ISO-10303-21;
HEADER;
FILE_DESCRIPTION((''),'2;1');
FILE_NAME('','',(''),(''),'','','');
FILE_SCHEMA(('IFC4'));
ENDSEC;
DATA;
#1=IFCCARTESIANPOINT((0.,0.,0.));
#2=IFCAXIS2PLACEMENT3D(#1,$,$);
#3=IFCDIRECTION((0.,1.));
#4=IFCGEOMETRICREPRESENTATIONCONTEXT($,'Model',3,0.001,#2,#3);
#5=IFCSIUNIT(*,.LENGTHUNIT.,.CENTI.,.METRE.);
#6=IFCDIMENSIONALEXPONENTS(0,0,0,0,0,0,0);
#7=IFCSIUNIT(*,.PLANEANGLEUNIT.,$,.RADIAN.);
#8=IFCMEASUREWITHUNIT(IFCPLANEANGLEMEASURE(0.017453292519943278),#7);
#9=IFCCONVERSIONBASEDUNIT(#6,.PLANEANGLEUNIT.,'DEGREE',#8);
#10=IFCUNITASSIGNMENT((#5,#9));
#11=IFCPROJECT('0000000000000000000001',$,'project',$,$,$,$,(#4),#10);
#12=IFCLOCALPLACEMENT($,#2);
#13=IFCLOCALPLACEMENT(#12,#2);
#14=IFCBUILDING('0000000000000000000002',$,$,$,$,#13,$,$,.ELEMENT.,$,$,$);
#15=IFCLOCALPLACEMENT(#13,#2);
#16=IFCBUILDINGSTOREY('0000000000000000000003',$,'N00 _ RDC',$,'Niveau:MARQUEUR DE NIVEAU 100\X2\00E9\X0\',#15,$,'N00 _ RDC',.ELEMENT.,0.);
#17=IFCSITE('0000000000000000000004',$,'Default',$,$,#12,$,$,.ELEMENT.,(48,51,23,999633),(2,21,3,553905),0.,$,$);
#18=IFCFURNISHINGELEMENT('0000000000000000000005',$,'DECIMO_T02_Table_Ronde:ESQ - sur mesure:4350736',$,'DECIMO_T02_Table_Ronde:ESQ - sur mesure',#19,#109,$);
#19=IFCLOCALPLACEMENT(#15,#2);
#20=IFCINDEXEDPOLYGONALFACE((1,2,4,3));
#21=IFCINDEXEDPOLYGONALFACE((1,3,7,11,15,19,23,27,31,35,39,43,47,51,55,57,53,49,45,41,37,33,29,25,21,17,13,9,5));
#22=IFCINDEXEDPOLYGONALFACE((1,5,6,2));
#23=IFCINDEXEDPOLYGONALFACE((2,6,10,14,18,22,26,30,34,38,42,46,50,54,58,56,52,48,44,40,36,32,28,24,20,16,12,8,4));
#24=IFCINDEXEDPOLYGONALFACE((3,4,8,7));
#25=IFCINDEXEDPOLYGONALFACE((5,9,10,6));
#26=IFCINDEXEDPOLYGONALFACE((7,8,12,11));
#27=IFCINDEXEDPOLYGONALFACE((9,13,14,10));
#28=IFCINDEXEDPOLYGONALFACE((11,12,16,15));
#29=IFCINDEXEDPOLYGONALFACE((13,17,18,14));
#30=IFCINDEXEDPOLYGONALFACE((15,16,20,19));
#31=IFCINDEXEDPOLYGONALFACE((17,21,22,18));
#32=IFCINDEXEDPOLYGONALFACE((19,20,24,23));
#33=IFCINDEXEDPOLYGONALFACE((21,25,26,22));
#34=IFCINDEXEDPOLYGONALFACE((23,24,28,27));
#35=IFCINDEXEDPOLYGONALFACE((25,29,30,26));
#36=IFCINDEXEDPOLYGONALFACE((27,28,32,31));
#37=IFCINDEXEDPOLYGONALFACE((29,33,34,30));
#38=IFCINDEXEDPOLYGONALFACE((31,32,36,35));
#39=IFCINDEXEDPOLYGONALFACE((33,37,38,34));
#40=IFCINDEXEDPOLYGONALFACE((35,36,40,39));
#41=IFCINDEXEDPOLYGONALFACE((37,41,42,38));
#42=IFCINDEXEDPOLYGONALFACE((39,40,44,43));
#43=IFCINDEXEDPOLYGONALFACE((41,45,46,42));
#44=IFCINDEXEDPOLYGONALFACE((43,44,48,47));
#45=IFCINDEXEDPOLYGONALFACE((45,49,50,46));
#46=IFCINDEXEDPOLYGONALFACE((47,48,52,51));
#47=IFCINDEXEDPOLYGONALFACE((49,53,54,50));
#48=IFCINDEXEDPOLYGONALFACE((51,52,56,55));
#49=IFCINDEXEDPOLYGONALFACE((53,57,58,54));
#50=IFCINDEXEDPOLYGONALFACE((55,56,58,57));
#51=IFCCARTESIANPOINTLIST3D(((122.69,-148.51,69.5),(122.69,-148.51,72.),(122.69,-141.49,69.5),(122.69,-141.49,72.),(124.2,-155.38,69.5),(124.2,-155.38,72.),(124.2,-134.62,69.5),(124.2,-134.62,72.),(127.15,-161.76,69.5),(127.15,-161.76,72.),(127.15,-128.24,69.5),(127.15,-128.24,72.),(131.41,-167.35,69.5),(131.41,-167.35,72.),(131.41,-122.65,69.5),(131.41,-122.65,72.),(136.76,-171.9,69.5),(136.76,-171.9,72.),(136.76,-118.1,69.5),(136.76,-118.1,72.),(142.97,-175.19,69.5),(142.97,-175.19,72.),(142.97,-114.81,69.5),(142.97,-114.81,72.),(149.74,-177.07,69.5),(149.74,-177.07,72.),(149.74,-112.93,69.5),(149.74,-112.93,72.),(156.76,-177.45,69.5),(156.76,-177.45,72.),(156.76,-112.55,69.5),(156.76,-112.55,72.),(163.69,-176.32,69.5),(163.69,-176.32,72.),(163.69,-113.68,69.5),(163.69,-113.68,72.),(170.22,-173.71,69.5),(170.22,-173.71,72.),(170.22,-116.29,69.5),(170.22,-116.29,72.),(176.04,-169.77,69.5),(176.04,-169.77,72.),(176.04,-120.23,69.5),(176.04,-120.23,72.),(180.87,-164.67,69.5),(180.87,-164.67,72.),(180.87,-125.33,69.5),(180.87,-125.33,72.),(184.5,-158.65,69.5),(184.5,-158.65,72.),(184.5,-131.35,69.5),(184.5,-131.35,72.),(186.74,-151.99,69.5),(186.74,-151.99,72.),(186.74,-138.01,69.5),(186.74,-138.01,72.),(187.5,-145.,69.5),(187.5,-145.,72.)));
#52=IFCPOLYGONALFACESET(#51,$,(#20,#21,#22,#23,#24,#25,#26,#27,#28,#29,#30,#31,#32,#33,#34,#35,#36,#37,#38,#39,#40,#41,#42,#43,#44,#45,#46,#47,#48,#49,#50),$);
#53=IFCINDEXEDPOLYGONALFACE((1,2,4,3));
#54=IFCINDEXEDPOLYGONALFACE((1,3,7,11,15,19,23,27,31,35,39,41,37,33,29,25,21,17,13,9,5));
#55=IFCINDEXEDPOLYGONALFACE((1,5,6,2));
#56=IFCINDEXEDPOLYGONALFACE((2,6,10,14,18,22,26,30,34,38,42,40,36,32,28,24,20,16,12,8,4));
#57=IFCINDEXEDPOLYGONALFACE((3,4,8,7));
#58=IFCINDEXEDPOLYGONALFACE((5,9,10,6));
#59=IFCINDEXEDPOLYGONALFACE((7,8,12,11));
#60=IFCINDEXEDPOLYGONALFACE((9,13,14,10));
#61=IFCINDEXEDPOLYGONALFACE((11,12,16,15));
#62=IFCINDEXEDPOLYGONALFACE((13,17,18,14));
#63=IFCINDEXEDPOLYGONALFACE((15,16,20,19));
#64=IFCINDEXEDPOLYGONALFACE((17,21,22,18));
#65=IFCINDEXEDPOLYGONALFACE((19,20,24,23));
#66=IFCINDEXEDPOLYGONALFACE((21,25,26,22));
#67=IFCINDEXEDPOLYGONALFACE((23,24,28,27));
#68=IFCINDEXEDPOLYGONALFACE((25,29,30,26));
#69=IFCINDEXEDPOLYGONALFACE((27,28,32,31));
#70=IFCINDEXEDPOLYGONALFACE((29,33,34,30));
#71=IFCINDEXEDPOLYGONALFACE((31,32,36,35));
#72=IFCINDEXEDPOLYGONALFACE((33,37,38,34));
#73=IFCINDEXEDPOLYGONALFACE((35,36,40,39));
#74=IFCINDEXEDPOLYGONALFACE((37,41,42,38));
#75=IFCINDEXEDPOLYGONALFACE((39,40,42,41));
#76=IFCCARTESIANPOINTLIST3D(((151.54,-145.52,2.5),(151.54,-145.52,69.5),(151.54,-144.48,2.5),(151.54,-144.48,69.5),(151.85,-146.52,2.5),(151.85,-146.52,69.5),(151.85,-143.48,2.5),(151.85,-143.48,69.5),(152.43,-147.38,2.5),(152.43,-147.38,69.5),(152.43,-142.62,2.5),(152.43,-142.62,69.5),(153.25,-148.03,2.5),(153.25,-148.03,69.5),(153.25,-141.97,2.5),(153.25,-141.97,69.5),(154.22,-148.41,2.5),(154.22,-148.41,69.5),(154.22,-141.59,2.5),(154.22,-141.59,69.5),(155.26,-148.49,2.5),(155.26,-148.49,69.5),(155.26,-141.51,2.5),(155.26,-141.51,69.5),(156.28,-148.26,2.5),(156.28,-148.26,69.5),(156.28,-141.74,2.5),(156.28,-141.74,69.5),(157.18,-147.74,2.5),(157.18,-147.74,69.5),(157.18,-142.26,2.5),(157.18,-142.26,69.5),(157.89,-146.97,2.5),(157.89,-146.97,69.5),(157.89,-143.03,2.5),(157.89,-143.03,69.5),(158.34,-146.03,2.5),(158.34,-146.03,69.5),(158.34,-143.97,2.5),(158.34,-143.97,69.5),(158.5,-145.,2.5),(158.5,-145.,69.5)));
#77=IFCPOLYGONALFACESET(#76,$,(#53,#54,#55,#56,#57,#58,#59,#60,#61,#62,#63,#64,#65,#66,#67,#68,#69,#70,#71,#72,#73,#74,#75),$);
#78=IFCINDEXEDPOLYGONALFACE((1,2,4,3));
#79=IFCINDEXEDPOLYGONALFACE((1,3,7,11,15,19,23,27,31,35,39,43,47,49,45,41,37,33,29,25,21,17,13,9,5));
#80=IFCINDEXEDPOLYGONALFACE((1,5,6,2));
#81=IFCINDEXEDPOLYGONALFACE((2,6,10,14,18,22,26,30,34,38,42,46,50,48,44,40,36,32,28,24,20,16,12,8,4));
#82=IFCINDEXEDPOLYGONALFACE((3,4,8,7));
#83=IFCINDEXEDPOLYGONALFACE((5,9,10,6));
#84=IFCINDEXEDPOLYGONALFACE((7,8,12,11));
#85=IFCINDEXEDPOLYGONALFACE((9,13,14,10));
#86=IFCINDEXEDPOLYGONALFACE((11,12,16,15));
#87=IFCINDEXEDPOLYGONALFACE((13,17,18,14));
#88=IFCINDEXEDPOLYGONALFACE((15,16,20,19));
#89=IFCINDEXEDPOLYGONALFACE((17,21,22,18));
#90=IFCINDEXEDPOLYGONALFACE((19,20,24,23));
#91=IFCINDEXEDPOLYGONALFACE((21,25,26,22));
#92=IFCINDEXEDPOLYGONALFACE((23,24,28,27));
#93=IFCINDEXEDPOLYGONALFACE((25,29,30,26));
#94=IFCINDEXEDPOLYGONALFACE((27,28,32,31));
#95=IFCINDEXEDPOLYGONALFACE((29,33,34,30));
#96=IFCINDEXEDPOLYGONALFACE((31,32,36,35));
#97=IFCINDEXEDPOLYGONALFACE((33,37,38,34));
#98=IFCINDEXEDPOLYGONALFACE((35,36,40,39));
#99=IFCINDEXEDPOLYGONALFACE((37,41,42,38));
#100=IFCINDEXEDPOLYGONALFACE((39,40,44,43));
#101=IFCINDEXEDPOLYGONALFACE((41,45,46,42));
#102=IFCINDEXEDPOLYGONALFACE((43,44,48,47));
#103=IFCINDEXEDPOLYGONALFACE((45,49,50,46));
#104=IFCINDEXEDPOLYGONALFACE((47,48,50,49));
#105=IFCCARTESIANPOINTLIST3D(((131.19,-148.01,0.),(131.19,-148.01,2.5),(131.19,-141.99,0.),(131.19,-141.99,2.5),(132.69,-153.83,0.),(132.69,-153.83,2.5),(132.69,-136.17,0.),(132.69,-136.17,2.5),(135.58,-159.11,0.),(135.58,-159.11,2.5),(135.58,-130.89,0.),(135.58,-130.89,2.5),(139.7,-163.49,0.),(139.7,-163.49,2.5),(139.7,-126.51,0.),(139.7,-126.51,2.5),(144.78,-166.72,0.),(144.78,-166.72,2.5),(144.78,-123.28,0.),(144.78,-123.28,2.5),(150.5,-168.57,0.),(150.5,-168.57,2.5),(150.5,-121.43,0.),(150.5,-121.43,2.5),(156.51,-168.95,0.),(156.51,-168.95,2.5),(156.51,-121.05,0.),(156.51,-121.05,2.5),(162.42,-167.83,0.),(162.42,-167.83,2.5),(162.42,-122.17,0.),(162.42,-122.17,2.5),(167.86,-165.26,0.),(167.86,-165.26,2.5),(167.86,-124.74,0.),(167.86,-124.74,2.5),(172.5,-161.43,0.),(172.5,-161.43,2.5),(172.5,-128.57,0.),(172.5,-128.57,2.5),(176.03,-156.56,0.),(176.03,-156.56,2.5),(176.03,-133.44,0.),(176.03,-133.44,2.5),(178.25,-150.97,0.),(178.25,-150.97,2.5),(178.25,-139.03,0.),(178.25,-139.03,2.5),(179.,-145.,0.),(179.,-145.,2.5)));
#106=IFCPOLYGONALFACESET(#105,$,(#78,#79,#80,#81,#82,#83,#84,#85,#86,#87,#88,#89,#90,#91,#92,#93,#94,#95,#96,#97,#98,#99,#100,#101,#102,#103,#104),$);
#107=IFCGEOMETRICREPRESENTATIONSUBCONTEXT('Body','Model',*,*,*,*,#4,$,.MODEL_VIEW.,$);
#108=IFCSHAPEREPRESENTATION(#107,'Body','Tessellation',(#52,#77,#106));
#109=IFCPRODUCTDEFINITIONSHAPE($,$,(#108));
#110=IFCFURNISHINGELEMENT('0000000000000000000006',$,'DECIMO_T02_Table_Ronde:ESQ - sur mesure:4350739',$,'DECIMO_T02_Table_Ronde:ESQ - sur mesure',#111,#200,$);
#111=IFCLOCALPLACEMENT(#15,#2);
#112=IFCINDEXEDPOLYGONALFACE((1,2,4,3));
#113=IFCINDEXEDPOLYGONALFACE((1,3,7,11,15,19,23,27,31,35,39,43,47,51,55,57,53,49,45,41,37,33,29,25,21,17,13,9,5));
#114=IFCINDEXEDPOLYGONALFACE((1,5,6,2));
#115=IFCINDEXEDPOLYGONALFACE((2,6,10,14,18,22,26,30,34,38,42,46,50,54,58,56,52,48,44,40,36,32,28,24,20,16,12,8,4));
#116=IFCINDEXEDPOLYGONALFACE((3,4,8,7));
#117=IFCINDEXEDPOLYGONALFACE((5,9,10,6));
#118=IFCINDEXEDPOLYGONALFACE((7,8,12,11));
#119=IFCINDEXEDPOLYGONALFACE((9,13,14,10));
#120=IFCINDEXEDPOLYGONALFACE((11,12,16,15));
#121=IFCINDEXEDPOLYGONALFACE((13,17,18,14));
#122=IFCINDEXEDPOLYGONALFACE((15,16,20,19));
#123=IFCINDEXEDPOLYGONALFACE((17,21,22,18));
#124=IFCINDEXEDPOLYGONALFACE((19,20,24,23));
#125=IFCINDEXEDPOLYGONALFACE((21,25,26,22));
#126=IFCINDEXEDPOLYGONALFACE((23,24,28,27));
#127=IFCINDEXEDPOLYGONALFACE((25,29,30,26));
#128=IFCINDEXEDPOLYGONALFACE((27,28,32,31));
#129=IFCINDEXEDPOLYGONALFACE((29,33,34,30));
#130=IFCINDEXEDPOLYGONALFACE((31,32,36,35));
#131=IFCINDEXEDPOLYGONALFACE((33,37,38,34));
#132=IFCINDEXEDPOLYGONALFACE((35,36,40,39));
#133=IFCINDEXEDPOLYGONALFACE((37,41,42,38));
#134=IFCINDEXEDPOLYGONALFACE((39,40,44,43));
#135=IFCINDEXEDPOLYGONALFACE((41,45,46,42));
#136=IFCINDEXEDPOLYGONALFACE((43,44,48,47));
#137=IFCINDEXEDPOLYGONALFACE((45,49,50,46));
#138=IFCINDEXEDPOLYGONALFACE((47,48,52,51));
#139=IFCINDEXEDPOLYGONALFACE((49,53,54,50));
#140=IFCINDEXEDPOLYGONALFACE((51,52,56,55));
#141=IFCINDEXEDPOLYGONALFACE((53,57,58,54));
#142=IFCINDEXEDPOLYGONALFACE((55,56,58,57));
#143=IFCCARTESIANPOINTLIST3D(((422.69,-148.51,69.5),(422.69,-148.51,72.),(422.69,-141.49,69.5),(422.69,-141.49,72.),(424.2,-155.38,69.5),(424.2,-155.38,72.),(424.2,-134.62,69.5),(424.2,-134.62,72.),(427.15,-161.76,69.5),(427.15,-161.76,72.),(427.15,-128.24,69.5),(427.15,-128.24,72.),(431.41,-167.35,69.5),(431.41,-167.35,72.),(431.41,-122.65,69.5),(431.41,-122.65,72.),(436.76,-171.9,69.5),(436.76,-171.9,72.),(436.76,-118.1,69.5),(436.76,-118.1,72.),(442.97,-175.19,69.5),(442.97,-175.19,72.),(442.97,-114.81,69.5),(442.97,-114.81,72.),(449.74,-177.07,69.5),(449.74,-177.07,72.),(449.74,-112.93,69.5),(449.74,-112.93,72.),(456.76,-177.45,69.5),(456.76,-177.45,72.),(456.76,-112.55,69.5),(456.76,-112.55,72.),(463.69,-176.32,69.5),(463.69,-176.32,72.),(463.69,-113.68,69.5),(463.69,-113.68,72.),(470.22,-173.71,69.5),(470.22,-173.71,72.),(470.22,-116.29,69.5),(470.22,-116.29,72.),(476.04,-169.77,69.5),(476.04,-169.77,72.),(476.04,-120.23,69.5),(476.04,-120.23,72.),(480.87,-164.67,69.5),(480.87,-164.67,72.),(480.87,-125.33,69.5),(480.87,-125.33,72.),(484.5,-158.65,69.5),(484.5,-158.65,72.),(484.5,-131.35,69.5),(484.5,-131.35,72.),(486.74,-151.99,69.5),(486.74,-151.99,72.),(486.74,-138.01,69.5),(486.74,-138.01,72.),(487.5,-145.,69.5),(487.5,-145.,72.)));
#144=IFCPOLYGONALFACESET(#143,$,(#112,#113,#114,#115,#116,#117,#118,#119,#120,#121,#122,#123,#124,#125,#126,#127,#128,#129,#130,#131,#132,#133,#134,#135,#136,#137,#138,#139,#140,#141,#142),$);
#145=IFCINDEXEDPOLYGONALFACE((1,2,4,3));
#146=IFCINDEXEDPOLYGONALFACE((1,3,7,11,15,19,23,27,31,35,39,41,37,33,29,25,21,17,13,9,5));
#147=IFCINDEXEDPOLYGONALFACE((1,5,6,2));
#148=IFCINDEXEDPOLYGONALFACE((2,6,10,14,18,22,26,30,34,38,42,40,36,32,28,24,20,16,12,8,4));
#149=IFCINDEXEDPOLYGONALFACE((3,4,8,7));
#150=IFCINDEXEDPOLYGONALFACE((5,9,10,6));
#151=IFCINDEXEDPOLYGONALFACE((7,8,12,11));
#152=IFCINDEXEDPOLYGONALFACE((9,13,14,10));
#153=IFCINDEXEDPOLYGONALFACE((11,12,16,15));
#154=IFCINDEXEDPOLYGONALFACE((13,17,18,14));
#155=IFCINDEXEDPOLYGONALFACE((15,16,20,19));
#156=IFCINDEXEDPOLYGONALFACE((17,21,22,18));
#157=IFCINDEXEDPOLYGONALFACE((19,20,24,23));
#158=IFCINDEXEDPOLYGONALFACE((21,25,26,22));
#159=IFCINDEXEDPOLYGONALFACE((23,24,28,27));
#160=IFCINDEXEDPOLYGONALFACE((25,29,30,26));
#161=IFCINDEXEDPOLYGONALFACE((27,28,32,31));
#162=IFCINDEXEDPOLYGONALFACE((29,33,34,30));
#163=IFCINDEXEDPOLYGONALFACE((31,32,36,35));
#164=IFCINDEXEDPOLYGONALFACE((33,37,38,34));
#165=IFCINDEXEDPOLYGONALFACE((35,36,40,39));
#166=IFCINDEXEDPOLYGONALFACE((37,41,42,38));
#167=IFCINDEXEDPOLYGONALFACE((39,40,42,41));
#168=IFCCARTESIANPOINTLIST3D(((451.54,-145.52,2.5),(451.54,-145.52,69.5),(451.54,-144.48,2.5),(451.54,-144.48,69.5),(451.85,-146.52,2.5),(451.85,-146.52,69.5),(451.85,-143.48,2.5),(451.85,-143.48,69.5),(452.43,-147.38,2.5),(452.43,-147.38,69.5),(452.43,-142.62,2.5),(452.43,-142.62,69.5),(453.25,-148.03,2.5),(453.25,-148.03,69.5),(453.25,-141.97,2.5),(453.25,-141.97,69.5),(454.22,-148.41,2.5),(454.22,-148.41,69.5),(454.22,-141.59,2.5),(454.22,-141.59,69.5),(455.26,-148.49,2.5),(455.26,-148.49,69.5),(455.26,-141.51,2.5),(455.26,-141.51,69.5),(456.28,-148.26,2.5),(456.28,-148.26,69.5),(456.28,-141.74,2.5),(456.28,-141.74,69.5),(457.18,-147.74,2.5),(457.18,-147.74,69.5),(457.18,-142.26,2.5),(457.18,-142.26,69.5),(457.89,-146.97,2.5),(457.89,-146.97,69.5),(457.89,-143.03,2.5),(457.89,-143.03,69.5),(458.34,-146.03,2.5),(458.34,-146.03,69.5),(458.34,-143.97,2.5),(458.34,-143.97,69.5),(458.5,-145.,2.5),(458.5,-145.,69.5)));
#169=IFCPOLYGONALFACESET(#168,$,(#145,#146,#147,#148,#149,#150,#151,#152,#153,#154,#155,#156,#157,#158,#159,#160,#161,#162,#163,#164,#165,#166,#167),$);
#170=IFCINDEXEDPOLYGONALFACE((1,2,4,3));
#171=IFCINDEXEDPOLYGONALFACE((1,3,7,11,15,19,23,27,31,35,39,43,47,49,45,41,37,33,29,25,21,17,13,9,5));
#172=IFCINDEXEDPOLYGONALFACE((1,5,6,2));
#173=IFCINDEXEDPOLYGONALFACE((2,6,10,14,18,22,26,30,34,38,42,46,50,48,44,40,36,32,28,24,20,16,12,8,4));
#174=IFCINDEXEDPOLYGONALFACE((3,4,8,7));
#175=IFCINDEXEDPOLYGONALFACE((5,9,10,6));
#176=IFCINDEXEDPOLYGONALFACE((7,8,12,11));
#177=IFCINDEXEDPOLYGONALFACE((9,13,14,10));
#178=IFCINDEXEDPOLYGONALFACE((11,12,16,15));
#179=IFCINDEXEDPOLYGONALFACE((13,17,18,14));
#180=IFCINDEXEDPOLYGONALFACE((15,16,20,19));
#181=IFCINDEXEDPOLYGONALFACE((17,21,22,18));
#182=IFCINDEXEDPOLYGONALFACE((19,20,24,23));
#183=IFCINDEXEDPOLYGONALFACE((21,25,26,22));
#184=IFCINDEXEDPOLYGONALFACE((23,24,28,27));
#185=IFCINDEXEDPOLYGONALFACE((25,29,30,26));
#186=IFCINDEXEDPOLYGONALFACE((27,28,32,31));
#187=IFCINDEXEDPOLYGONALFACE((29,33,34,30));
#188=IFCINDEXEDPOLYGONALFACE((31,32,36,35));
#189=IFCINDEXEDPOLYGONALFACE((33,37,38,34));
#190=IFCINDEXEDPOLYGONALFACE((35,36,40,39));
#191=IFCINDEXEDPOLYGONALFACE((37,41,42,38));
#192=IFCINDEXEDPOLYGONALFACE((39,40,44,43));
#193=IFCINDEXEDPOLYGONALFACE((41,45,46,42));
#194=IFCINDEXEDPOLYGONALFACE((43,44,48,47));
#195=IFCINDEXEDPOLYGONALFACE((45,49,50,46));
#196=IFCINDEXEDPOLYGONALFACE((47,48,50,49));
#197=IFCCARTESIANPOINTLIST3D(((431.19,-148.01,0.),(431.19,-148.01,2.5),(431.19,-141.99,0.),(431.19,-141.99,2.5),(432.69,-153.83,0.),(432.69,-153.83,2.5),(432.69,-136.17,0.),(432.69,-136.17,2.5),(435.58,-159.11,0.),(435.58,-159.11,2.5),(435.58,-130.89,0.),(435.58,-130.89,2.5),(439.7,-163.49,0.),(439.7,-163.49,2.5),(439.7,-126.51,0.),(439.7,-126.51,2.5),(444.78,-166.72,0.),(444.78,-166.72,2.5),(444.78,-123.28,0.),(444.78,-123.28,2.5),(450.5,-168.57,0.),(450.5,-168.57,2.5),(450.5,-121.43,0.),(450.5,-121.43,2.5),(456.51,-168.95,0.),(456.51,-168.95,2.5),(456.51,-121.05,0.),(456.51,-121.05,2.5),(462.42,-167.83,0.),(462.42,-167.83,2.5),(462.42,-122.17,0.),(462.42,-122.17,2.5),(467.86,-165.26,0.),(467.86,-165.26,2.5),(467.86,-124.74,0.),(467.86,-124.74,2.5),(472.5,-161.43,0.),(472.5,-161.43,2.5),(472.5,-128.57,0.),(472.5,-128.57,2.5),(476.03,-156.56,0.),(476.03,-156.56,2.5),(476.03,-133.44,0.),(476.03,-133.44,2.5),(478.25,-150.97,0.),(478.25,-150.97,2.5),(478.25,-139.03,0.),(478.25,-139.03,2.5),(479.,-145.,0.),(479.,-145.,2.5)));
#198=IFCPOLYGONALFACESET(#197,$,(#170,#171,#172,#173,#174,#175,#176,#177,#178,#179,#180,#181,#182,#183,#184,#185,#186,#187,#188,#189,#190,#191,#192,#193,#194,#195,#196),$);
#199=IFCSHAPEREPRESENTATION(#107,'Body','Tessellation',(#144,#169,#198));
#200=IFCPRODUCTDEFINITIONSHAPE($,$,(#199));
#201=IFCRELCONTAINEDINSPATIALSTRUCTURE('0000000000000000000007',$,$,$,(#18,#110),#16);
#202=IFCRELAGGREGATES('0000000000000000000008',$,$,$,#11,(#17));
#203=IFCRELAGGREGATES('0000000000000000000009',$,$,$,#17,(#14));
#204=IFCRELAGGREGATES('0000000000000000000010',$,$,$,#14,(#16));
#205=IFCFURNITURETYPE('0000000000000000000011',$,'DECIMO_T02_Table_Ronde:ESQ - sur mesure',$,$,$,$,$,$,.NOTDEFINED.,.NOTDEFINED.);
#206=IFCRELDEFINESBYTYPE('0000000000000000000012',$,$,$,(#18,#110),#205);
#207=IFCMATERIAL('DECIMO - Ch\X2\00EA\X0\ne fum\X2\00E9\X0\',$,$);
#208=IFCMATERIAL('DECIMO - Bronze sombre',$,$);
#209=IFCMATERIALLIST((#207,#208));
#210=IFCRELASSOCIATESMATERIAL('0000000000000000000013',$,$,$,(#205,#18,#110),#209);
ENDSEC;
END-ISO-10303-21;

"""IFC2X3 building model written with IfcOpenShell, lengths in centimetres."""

from ifc_helpers import new_model, entity, si_unit, converted_unit, direction, frame, frame_2d, origin, place, context, subcontext, project, spatial, circle, extrude, source, transform, mapped, material, material_list, type_object, type_shapes, element, save


model = new_model("IFC2X3")

# Units and contexts
model_context = context("Model", 3, precision=0.001, world=origin(), true_north=direction((0.0, 1.0)))
body_context = subcontext(model_context, "Body", "Model", "MODEL_VIEW")
ifc_project = project(units=[si_unit("LENGTHUNIT", "METRE", prefix="CENTI"), converted_unit("PLANEANGLEUNIT", "DEGREE", entity("IfcPlaneAngleMeasure", 0.017453292519943278), si_unit("PLANEANGLEUNIT", "RADIAN"), dimensions=[0, 0, 0, 0, 0, 0, 0])], contexts=[model_context])

# Site, building, storey
site_placement = place(None, origin())
site = spatial("IfcSite", under=ifc_project, at=site_placement, Name="Default", CompositionType="ELEMENT", RefLatitude=(48, 51, 23, 999633), RefLongitude=(2, 21, 3, 553905), RefElevation=0.0)
building_placement = place(site_placement, origin())
building = spatial("IfcBuilding", under=site, at=building_placement, CompositionType="ELEMENT")
storey_placement = place(building_placement, origin())
storey = spatial("IfcBuildingStorey", under=building, at=storey_placement, Name="N00 _ RDC", ObjectType="Niveau:MARQUEUR DE NIVEAU 100é", LongName="N00 _ RDC", CompositionType="ELEMENT", Elevation=0.0)

# Furnishing elements
ifc_material_1 = material(Name="DECIMO - Bronze sombre")
ifc_material_2 = material(Name="DECIMO - Chêne fumé")
ifc_material_list_1 = material_list([ifc_material_2, ifc_material_1])
furniture_type_1 = type_object("IfcFurnitureType", Name="DECIMO_T02_Table_Ronde:ESQ - sur mesure", AssemblyPlace="NOTDEFINED", material=ifc_material_list_1)
shared_shape_1 = source(origin(), body_context, "Body", "SweptSolid", [
    extrude(circle(Radius=32.5, at=frame_2d((0.0, 0.0), x_axis=(1.0, 0.0))), frame((0.0, 0.0, 69.5)), (0.0, 0.0, 1.0), 2.5),
    extrude(circle(Radius=3.5, at=frame_2d((0.0, 0.0), x_axis=(1.0, 0.0))), frame((0.0, 0.0, 2.5)), (0.0, 0.0, 1.0), 67.0),
    extrude(circle(Radius=24.0, at=frame_2d((0.0, 0.0), x_axis=(1.0, 0.0))), origin(), (0.0, 0.0, 1.0), 2.5),
])
type_shapes(furniture_type_1, [shared_shape_1])
for number, where, name in (
    (1, (155.0, -145.0, 0.0), "DECIMO_T02_Table_Ronde:ESQ - sur mesure:4350736"),
    (2, (455.0, -145.0, 0.0), "DECIMO_T02_Table_Ronde:ESQ - sur mesure:4350739"),
):
    element("IfcFurnishingElement", number, at=place(storey_placement, frame(where)), inside=storey, type_object=furniture_type_1, material=ifc_material_list_1, Name=name, ObjectType="DECIMO_T02_Table_Ronde:ESQ - sur mesure", context=body_context, shape_type="MappedRepresentation", body=[
        mapped(shared_shape_1, transform((0.0, 0.0, 0.0), scale=1.0)),
    ])

save(model, "model.ifc")
